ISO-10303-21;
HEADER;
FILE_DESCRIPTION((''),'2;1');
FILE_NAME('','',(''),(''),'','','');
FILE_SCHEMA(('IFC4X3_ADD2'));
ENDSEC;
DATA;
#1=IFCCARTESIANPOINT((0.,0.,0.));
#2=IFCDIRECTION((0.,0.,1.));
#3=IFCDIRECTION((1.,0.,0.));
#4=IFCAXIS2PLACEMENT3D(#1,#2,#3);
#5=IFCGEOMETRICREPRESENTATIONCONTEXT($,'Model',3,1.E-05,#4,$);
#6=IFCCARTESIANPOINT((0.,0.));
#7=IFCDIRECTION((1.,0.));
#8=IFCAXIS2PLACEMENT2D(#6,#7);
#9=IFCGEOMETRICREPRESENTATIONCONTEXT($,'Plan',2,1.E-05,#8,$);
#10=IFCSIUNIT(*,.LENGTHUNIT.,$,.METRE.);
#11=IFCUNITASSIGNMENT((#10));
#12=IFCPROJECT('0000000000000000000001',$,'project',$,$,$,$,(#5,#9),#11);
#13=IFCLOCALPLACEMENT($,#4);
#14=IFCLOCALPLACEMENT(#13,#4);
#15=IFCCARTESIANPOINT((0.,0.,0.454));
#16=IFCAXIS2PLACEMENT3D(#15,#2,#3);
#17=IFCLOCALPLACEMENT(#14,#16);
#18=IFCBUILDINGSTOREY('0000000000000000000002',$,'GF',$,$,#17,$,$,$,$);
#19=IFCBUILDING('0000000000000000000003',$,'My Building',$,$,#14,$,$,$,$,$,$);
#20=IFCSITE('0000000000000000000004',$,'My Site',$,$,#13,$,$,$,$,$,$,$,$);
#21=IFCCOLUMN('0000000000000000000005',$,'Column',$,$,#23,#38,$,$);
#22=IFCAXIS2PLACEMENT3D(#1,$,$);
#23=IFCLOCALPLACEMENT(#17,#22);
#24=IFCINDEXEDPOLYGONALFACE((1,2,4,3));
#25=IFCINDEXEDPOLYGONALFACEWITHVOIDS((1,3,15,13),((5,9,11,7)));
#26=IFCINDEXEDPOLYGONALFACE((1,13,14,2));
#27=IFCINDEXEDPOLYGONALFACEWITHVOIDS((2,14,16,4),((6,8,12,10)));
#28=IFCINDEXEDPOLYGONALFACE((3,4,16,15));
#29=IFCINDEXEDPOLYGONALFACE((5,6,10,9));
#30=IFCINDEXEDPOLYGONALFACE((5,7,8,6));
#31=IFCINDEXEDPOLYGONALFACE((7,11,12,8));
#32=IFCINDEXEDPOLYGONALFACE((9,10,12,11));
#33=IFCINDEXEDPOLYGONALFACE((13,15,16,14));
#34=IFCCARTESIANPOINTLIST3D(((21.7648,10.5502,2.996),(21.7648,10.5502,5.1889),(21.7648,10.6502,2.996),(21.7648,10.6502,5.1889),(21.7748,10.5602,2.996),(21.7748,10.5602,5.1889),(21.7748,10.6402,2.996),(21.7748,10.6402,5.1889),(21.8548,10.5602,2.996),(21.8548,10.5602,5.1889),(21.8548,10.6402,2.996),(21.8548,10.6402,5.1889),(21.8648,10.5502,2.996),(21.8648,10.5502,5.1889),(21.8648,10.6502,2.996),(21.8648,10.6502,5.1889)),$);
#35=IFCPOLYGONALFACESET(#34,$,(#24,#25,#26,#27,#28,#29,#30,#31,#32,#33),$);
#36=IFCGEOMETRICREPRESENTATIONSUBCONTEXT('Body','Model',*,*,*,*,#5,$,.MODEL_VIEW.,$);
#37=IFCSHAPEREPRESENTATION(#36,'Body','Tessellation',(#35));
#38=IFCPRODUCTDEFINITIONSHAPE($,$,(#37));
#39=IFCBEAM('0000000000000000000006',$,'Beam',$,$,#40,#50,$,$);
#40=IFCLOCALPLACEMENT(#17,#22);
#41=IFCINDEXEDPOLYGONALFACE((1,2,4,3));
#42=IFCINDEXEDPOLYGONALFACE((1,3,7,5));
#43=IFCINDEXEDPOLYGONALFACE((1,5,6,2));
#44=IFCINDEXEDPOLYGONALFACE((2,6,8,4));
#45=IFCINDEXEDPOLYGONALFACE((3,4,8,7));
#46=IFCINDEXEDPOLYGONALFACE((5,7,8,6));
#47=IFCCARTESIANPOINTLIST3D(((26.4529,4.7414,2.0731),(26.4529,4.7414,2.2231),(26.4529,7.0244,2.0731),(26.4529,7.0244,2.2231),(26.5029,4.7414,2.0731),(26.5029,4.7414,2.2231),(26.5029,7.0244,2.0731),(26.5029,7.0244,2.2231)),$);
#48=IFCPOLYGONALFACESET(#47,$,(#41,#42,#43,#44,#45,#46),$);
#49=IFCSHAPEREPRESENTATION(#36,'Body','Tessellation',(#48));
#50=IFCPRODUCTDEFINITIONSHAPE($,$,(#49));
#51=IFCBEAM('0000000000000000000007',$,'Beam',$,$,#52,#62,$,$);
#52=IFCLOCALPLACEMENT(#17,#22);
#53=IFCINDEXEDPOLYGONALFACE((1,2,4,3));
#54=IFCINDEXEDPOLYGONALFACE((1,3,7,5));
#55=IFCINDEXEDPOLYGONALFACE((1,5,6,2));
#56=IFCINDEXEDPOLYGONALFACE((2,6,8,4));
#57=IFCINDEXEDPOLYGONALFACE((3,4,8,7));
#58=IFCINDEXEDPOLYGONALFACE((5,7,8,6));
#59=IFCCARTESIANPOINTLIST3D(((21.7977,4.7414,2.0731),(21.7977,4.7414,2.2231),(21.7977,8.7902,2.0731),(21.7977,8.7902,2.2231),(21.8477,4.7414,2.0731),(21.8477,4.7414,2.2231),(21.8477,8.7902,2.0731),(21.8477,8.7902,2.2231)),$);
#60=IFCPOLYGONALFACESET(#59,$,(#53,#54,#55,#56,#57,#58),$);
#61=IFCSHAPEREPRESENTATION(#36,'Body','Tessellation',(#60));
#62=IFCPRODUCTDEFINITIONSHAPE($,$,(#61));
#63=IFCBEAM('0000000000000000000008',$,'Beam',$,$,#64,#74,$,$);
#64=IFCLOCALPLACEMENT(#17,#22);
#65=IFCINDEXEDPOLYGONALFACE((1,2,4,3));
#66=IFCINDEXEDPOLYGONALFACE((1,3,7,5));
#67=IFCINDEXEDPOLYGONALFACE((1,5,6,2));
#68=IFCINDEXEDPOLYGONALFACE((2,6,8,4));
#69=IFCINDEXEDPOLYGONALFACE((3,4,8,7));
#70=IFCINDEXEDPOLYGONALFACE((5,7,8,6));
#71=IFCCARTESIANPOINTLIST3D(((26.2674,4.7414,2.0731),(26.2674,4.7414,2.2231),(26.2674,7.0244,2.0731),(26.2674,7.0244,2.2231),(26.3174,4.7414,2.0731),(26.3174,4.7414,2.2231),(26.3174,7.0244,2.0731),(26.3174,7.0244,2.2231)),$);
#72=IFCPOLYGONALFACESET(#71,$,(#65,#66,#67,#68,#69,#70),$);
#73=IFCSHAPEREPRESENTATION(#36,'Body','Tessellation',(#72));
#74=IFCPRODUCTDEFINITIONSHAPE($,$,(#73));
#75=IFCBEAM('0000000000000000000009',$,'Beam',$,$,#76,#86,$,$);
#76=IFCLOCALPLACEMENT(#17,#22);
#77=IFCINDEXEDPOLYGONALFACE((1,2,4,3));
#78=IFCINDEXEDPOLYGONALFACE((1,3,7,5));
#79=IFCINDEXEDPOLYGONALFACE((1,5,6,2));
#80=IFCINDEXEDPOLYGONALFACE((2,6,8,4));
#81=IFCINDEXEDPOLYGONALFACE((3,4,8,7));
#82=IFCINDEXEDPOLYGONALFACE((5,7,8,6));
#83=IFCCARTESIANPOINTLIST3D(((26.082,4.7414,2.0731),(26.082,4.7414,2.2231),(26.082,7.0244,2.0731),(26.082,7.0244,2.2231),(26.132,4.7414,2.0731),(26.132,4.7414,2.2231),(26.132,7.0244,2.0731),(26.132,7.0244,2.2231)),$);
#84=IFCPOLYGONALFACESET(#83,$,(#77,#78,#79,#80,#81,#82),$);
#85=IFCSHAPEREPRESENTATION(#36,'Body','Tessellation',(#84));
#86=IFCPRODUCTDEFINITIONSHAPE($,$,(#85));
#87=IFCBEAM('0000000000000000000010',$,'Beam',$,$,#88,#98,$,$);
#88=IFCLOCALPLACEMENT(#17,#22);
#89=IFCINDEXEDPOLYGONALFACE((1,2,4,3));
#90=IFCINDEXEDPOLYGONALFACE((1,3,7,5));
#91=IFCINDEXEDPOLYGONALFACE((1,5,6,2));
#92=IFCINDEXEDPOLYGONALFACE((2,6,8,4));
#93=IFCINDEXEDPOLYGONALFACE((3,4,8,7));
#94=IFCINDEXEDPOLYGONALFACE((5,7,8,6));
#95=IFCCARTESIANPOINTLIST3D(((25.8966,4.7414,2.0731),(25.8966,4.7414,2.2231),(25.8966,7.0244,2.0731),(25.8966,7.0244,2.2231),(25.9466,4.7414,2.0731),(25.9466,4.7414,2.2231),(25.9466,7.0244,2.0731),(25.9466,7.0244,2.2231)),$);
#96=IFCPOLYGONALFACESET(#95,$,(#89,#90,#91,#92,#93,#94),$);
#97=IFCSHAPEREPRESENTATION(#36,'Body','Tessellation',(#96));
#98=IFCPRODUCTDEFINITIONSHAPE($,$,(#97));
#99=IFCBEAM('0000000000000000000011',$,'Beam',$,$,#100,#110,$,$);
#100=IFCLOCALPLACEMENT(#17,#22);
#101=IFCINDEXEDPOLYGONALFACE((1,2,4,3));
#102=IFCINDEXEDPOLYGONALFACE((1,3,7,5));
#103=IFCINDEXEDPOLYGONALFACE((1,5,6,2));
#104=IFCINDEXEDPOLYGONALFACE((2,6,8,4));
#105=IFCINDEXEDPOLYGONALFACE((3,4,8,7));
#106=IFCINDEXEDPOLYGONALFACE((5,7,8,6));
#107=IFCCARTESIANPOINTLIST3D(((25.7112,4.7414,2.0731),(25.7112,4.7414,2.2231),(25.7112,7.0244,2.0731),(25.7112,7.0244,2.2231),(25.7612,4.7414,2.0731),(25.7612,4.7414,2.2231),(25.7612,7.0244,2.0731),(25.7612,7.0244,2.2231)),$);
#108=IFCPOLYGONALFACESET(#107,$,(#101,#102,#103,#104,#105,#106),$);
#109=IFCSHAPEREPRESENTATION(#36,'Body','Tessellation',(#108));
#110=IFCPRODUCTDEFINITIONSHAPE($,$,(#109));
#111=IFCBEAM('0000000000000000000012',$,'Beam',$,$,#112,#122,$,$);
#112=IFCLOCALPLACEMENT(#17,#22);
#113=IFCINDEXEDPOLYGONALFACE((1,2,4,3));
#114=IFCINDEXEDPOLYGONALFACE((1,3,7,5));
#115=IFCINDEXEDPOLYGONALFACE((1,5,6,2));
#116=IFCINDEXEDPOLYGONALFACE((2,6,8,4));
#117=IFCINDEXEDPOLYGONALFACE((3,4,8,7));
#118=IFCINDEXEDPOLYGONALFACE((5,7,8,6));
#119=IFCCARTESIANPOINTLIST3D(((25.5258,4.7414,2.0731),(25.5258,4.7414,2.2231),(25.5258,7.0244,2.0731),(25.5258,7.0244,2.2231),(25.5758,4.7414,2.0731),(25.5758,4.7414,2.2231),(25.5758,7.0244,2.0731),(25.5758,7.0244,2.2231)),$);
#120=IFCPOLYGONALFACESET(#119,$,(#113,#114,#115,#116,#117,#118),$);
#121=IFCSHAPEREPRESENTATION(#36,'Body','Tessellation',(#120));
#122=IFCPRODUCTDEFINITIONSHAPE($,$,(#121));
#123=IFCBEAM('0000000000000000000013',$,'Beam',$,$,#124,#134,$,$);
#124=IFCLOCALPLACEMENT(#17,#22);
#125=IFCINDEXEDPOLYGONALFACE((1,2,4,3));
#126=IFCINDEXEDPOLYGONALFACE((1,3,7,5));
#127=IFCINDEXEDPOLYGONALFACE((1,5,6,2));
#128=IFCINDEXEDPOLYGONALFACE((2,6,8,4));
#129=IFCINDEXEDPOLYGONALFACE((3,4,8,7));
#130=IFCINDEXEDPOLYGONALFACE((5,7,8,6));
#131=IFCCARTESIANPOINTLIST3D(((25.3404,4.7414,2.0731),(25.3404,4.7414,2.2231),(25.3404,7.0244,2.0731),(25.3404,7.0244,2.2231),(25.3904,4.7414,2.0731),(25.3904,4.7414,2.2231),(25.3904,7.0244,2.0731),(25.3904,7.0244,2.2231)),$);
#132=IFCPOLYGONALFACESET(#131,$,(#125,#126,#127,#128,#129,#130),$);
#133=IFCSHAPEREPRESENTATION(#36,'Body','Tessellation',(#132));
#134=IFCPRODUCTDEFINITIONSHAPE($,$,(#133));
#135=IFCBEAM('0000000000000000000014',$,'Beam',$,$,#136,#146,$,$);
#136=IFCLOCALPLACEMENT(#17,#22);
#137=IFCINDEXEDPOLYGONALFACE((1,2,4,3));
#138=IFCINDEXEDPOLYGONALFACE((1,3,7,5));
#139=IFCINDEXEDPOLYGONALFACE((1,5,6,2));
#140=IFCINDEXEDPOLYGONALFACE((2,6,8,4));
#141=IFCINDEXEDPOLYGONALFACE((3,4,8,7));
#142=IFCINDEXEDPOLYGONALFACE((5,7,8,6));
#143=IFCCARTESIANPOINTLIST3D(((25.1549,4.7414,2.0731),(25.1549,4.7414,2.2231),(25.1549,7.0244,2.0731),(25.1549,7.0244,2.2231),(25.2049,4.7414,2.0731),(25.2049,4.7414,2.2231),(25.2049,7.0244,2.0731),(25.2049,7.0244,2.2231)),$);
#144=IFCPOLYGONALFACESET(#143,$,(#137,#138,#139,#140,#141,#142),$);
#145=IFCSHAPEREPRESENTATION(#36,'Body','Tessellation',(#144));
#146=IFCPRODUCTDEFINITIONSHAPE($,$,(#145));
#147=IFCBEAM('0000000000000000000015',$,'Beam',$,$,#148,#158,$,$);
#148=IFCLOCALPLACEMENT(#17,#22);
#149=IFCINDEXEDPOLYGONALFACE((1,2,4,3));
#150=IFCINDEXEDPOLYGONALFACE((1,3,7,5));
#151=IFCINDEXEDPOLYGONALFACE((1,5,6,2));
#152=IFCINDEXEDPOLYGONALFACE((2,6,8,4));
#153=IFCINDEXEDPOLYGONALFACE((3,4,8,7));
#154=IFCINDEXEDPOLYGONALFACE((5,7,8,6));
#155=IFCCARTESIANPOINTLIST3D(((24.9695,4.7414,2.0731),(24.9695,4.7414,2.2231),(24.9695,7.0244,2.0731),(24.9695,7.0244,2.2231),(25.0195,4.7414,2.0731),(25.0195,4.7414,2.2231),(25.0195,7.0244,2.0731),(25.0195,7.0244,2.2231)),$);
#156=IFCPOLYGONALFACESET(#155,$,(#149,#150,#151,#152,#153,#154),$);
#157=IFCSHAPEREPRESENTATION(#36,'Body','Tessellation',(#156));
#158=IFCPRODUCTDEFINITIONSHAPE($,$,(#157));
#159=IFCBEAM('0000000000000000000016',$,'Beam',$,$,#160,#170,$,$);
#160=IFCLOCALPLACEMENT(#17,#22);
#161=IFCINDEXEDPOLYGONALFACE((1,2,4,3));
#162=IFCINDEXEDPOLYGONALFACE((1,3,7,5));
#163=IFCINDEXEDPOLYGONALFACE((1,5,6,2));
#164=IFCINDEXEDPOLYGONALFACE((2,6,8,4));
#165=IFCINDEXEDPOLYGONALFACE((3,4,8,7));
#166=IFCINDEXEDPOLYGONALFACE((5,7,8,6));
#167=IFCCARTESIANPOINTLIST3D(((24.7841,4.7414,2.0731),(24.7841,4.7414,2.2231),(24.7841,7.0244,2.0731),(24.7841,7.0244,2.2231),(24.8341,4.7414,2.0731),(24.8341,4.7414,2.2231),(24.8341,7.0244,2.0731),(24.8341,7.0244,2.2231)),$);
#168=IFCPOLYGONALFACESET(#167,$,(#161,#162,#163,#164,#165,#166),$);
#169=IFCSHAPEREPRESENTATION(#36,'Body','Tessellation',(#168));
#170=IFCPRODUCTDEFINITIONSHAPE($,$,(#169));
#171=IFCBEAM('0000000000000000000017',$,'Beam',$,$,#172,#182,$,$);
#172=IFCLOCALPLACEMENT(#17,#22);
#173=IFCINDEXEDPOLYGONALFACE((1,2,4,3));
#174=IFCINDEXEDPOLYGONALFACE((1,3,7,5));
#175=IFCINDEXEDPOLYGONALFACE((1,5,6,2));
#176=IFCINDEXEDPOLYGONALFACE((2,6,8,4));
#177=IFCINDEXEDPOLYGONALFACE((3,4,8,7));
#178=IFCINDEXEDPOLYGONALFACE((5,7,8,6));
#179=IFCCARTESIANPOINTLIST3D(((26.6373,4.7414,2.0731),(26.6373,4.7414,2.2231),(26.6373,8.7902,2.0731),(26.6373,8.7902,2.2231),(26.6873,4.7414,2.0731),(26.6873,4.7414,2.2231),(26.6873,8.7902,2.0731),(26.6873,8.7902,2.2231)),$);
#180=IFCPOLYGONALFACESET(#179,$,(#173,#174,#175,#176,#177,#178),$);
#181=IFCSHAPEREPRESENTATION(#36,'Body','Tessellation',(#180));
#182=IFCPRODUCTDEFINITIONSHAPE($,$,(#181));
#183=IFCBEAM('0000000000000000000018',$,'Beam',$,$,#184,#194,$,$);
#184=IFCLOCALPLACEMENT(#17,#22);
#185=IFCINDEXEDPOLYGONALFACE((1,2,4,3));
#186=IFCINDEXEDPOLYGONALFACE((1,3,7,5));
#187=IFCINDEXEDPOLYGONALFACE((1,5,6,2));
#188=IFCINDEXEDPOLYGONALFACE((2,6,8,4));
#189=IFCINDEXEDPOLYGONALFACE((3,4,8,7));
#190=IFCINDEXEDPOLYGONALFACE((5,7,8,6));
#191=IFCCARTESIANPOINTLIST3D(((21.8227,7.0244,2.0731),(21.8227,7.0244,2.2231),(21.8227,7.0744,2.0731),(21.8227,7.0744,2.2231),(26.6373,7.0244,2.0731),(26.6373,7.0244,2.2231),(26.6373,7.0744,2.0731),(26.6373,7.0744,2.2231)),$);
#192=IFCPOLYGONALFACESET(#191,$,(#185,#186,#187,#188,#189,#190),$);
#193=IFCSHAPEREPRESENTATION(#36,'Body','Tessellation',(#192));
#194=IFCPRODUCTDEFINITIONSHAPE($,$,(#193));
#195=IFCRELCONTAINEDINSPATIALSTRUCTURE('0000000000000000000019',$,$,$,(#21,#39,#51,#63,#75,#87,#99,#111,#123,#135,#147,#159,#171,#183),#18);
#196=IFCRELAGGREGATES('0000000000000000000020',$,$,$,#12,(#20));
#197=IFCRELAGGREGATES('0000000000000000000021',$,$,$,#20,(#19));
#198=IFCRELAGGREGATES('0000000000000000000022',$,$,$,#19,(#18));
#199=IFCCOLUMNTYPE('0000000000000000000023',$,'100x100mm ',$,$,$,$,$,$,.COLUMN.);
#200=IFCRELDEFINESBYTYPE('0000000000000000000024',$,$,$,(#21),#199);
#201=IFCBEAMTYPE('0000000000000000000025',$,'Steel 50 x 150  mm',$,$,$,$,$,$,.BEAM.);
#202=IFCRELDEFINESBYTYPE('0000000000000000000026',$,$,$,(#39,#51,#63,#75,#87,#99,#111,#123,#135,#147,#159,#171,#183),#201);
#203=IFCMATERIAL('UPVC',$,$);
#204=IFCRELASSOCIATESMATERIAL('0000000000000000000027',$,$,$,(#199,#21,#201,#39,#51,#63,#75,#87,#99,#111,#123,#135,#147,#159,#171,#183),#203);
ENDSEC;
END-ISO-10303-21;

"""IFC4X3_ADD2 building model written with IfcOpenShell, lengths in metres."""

from ifc_helpers import new_model, si_unit, frame, origin_with_axes, origin_2d_with_axis, place, context, subcontext, project, spatial, rectangle, hollow_rectangle, extrude, material, material_profile, profile_set, profile_usage, type_object, element, save


model = new_model("IFC4X3_ADD2")

# Units and contexts
model_context = context("Model", 3, precision=1e-05, world=origin_with_axes())
plan_context = context("Plan", 2, precision=1e-05, world=origin_2d_with_axis())
body_context_1 = subcontext(model_context, "Body", "Model", "MODEL_VIEW")
ifc_project = project(units=[si_unit("LENGTHUNIT", "METRE")], contexts=[model_context, plan_context])

# Site, building, storey
site_placement = place(None, origin_with_axes())
site = spatial("IfcSite", under=ifc_project, at=site_placement, Name="My Site")
building_placement = place(site_placement, origin_with_axes())
building = spatial("IfcBuilding", under=site, at=building_placement, Name="My Building")
storey_placement = place(building_placement, frame((0.0, 0.0, 0.454), z_axis=(0.0, 0.0, 1.0), x_axis=(1.0, 0.0, 0.0)))
storey = spatial("IfcBuildingStorey", under=building, at=storey_placement, Name="GF")

# Column
ifc_material_1 = material(Name="UPVC")
ifc_material_profile_1 = material_profile(ifc_material_1, hollow_rectangle(XDim=0.1, YDim=0.1, WallThickness=0.01))
ifc_profile_set_1 = profile_set([ifc_material_profile_1])
ifc_profile_usage_1 = profile_usage(ifc_profile_set_1)
column_type = type_object("IfcColumnType", Name="100x100mm ", PredefinedType="COLUMN", material=ifc_profile_set_1)
column_placement = place(storey_placement, frame((21.8148, 10.6002, 2.996), z_axis=(0.0, 0.0, 1.0), x_axis=(0.0, -1.0, 0.0)))
element("IfcColumn", 1, at=column_placement, inside=storey, type_object=column_type, material=ifc_profile_usage_1, Name="Column", context=body_context_1, shape_type="SweptSolid", body=[
    extrude(hollow_rectangle(XDim=0.1, YDim=0.1, WallThickness=0.01), origin_with_axes(), (0.0, 0.0, 1.0), 2.1929),
])

# Beams
ifc_material_profile_2 = material_profile(ifc_material_1, rectangle(XDim=0.05, YDim=0.15))
ifc_profile_set_2 = profile_set([ifc_material_profile_2])
ifc_profile_usage_2 = profile_usage(ifc_profile_set_2)
beam_type = type_object("IfcBeamType", Name="Steel 50 x 150  mm", PredefinedType="BEAM", material=ifc_profile_set_2)
beam_1_placement = place(storey_placement, frame((26.4779, 7.0244, 2.1481), z_axis=(0.0, -1.0, 0.0), x_axis=(1.0, 0.0, 0.0)))
element("IfcBeam", 2, at=beam_1_placement, inside=storey, type_object=beam_type, material=ifc_profile_usage_2, Name="Beam", context=body_context_1, shape_type="SweptSolid", body=[
    extrude(rectangle(XDim=0.05, YDim=0.15), origin_with_axes(), (0.0, 0.0, 1.0), 2.283),
])
ifc_profile_usage_3 = profile_usage(ifc_profile_set_2)
beam_2_placement = place(storey_placement, frame((21.8227, 8.7902, 2.1481), z_axis=(0.0, -1.0, 0.0), x_axis=(1.0, 0.0, 0.0)))
element("IfcBeam", 3, at=beam_2_placement, inside=storey, type_object=beam_type, material=ifc_profile_usage_3, Name="Beam", context=body_context_1, shape_type="SweptSolid", body=[
    extrude(rectangle(XDim=0.05, YDim=0.15), origin_with_axes(), (0.0, 0.0, 1.0), 4.0488),
])
ifc_profile_usage_4 = profile_usage(ifc_profile_set_2)
beam_3_placement = place(storey_placement, frame((26.2924, 7.0244, 2.1481), z_axis=(0.0, -1.0, 0.0), x_axis=(1.0, 0.0, 0.0)))
element("IfcBeam", 4, at=beam_3_placement, inside=storey, type_object=beam_type, material=ifc_profile_usage_4, Name="Beam", context=body_context_1, shape_type="SweptSolid", body=[
    extrude(rectangle(XDim=0.05, YDim=0.15), origin_with_axes(), (0.0, 0.0, 1.0), 2.283),
])
ifc_profile_usage_5 = profile_usage(ifc_profile_set_2)
beam_4_placement = place(storey_placement, frame((26.107, 7.0244, 2.1481), z_axis=(0.0, -1.0, 0.0), x_axis=(1.0, 0.0, 0.0)))
element("IfcBeam", 5, at=beam_4_placement, inside=storey, type_object=beam_type, material=ifc_profile_usage_5, Name="Beam", context=body_context_1, shape_type="SweptSolid", body=[
    extrude(rectangle(XDim=0.05, YDim=0.15), origin_with_axes(), (0.0, 0.0, 1.0), 2.283),
])
ifc_profile_usage_6 = profile_usage(ifc_profile_set_2)
beam_5_placement = place(storey_placement, frame((25.9216, 7.0244, 2.1481), z_axis=(0.0, -1.0, 0.0), x_axis=(1.0, 0.0, 0.0)))
element("IfcBeam", 6, at=beam_5_placement, inside=storey, type_object=beam_type, material=ifc_profile_usage_6, Name="Beam", context=body_context_1, shape_type="SweptSolid", body=[
    extrude(rectangle(XDim=0.05, YDim=0.15), origin_with_axes(), (0.0, 0.0, 1.0), 2.283),
])
ifc_profile_usage_7 = profile_usage(ifc_profile_set_2)
beam_6_placement = place(storey_placement, frame((25.7362, 7.0244, 2.1481), z_axis=(0.0, -1.0, 0.0), x_axis=(1.0, 0.0, 0.0)))
element("IfcBeam", 7, at=beam_6_placement, inside=storey, type_object=beam_type, material=ifc_profile_usage_7, Name="Beam", context=body_context_1, shape_type="SweptSolid", body=[
    extrude(rectangle(XDim=0.05, YDim=0.15), origin_with_axes(), (0.0, 0.0, 1.0), 2.283),
])
ifc_profile_usage_8 = profile_usage(ifc_profile_set_2)
beam_7_placement = place(storey_placement, frame((25.5508, 7.0244, 2.1481), z_axis=(0.0, -1.0, 0.0), x_axis=(1.0, 0.0, 0.0)))
element("IfcBeam", 8, at=beam_7_placement, inside=storey, type_object=beam_type, material=ifc_profile_usage_8, Name="Beam", context=body_context_1, shape_type="SweptSolid", body=[
    extrude(rectangle(XDim=0.05, YDim=0.15), origin_with_axes(), (0.0, 0.0, 1.0), 2.283),
])
ifc_profile_usage_9 = profile_usage(ifc_profile_set_2)
beam_8_placement = place(storey_placement, frame((25.3654, 7.0244, 2.1481), z_axis=(0.0, -1.0, 0.0), x_axis=(1.0, 0.0, 0.0)))
element("IfcBeam", 9, at=beam_8_placement, inside=storey, type_object=beam_type, material=ifc_profile_usage_9, Name="Beam", context=body_context_1, shape_type="SweptSolid", body=[
    extrude(rectangle(XDim=0.05, YDim=0.15), origin_with_axes(), (0.0, 0.0, 1.0), 2.283),
])
ifc_profile_usage_10 = profile_usage(ifc_profile_set_2)
beam_9_placement = place(storey_placement, frame((25.1799, 7.0244, 2.1481), z_axis=(0.0, -1.0, 0.0), x_axis=(1.0, 0.0, 0.0)))
element("IfcBeam", 10, at=beam_9_placement, inside=storey, type_object=beam_type, material=ifc_profile_usage_10, Name="Beam", context=body_context_1, shape_type="SweptSolid", body=[
    extrude(rectangle(XDim=0.05, YDim=0.15), origin_with_axes(), (0.0, 0.0, 1.0), 2.283),
])
ifc_profile_usage_11 = profile_usage(ifc_profile_set_2)
beam_10_placement = place(storey_placement, frame((24.9945, 7.0244, 2.1481), z_axis=(0.0, -1.0, 0.0), x_axis=(1.0, 0.0, 0.0)))
element("IfcBeam", 11, at=beam_10_placement, inside=storey, type_object=beam_type, material=ifc_profile_usage_11, Name="Beam", context=body_context_1, shape_type="SweptSolid", body=[
    extrude(rectangle(XDim=0.05, YDim=0.15), origin_with_axes(), (0.0, 0.0, 1.0), 2.283),
])
ifc_profile_usage_12 = profile_usage(ifc_profile_set_2)
beam_11_placement = place(storey_placement, frame((24.8091, 7.0244, 2.1481), z_axis=(0.0, -1.0, 0.0), x_axis=(1.0, 0.0, 0.0)))
element("IfcBeam", 12, at=beam_11_placement, inside=storey, type_object=beam_type, material=ifc_profile_usage_12, Name="Beam", context=body_context_1, shape_type="SweptSolid", body=[
    extrude(rectangle(XDim=0.05, YDim=0.15), origin_with_axes(), (0.0, 0.0, 1.0), 2.283),
])
ifc_profile_usage_13 = profile_usage(ifc_profile_set_2)
beam_12_placement = place(storey_placement, frame((26.6623, 8.7902, 2.1481), z_axis=(0.0, -1.0, 0.0), x_axis=(1.0, 0.0, 0.0)))
element("IfcBeam", 13, at=beam_12_placement, inside=storey, type_object=beam_type, material=ifc_profile_usage_13, Name="Beam", context=body_context_1, shape_type="SweptSolid", body=[
    extrude(rectangle(XDim=0.05, YDim=0.15), origin_with_axes(), (0.0, 0.0, 1.0), 4.0488),
])
ifc_profile_usage_14 = profile_usage(ifc_profile_set_2)
beam_13_placement = place(storey_placement, frame((21.8227, 7.0494, 2.1481), z_axis=(1.0, 0.0, 0.0), x_axis=(0.0, 1.0, 0.0)))
element("IfcBeam", 14, at=beam_13_placement, inside=storey, type_object=beam_type, material=ifc_profile_usage_14, Name="Beam", context=body_context_1, shape_type="SweptSolid", body=[
    extrude(rectangle(XDim=0.05, YDim=0.15), origin_with_axes(), (0.0, 0.0, 1.0), 4.8146),
])

save(model, "model.ifc")
